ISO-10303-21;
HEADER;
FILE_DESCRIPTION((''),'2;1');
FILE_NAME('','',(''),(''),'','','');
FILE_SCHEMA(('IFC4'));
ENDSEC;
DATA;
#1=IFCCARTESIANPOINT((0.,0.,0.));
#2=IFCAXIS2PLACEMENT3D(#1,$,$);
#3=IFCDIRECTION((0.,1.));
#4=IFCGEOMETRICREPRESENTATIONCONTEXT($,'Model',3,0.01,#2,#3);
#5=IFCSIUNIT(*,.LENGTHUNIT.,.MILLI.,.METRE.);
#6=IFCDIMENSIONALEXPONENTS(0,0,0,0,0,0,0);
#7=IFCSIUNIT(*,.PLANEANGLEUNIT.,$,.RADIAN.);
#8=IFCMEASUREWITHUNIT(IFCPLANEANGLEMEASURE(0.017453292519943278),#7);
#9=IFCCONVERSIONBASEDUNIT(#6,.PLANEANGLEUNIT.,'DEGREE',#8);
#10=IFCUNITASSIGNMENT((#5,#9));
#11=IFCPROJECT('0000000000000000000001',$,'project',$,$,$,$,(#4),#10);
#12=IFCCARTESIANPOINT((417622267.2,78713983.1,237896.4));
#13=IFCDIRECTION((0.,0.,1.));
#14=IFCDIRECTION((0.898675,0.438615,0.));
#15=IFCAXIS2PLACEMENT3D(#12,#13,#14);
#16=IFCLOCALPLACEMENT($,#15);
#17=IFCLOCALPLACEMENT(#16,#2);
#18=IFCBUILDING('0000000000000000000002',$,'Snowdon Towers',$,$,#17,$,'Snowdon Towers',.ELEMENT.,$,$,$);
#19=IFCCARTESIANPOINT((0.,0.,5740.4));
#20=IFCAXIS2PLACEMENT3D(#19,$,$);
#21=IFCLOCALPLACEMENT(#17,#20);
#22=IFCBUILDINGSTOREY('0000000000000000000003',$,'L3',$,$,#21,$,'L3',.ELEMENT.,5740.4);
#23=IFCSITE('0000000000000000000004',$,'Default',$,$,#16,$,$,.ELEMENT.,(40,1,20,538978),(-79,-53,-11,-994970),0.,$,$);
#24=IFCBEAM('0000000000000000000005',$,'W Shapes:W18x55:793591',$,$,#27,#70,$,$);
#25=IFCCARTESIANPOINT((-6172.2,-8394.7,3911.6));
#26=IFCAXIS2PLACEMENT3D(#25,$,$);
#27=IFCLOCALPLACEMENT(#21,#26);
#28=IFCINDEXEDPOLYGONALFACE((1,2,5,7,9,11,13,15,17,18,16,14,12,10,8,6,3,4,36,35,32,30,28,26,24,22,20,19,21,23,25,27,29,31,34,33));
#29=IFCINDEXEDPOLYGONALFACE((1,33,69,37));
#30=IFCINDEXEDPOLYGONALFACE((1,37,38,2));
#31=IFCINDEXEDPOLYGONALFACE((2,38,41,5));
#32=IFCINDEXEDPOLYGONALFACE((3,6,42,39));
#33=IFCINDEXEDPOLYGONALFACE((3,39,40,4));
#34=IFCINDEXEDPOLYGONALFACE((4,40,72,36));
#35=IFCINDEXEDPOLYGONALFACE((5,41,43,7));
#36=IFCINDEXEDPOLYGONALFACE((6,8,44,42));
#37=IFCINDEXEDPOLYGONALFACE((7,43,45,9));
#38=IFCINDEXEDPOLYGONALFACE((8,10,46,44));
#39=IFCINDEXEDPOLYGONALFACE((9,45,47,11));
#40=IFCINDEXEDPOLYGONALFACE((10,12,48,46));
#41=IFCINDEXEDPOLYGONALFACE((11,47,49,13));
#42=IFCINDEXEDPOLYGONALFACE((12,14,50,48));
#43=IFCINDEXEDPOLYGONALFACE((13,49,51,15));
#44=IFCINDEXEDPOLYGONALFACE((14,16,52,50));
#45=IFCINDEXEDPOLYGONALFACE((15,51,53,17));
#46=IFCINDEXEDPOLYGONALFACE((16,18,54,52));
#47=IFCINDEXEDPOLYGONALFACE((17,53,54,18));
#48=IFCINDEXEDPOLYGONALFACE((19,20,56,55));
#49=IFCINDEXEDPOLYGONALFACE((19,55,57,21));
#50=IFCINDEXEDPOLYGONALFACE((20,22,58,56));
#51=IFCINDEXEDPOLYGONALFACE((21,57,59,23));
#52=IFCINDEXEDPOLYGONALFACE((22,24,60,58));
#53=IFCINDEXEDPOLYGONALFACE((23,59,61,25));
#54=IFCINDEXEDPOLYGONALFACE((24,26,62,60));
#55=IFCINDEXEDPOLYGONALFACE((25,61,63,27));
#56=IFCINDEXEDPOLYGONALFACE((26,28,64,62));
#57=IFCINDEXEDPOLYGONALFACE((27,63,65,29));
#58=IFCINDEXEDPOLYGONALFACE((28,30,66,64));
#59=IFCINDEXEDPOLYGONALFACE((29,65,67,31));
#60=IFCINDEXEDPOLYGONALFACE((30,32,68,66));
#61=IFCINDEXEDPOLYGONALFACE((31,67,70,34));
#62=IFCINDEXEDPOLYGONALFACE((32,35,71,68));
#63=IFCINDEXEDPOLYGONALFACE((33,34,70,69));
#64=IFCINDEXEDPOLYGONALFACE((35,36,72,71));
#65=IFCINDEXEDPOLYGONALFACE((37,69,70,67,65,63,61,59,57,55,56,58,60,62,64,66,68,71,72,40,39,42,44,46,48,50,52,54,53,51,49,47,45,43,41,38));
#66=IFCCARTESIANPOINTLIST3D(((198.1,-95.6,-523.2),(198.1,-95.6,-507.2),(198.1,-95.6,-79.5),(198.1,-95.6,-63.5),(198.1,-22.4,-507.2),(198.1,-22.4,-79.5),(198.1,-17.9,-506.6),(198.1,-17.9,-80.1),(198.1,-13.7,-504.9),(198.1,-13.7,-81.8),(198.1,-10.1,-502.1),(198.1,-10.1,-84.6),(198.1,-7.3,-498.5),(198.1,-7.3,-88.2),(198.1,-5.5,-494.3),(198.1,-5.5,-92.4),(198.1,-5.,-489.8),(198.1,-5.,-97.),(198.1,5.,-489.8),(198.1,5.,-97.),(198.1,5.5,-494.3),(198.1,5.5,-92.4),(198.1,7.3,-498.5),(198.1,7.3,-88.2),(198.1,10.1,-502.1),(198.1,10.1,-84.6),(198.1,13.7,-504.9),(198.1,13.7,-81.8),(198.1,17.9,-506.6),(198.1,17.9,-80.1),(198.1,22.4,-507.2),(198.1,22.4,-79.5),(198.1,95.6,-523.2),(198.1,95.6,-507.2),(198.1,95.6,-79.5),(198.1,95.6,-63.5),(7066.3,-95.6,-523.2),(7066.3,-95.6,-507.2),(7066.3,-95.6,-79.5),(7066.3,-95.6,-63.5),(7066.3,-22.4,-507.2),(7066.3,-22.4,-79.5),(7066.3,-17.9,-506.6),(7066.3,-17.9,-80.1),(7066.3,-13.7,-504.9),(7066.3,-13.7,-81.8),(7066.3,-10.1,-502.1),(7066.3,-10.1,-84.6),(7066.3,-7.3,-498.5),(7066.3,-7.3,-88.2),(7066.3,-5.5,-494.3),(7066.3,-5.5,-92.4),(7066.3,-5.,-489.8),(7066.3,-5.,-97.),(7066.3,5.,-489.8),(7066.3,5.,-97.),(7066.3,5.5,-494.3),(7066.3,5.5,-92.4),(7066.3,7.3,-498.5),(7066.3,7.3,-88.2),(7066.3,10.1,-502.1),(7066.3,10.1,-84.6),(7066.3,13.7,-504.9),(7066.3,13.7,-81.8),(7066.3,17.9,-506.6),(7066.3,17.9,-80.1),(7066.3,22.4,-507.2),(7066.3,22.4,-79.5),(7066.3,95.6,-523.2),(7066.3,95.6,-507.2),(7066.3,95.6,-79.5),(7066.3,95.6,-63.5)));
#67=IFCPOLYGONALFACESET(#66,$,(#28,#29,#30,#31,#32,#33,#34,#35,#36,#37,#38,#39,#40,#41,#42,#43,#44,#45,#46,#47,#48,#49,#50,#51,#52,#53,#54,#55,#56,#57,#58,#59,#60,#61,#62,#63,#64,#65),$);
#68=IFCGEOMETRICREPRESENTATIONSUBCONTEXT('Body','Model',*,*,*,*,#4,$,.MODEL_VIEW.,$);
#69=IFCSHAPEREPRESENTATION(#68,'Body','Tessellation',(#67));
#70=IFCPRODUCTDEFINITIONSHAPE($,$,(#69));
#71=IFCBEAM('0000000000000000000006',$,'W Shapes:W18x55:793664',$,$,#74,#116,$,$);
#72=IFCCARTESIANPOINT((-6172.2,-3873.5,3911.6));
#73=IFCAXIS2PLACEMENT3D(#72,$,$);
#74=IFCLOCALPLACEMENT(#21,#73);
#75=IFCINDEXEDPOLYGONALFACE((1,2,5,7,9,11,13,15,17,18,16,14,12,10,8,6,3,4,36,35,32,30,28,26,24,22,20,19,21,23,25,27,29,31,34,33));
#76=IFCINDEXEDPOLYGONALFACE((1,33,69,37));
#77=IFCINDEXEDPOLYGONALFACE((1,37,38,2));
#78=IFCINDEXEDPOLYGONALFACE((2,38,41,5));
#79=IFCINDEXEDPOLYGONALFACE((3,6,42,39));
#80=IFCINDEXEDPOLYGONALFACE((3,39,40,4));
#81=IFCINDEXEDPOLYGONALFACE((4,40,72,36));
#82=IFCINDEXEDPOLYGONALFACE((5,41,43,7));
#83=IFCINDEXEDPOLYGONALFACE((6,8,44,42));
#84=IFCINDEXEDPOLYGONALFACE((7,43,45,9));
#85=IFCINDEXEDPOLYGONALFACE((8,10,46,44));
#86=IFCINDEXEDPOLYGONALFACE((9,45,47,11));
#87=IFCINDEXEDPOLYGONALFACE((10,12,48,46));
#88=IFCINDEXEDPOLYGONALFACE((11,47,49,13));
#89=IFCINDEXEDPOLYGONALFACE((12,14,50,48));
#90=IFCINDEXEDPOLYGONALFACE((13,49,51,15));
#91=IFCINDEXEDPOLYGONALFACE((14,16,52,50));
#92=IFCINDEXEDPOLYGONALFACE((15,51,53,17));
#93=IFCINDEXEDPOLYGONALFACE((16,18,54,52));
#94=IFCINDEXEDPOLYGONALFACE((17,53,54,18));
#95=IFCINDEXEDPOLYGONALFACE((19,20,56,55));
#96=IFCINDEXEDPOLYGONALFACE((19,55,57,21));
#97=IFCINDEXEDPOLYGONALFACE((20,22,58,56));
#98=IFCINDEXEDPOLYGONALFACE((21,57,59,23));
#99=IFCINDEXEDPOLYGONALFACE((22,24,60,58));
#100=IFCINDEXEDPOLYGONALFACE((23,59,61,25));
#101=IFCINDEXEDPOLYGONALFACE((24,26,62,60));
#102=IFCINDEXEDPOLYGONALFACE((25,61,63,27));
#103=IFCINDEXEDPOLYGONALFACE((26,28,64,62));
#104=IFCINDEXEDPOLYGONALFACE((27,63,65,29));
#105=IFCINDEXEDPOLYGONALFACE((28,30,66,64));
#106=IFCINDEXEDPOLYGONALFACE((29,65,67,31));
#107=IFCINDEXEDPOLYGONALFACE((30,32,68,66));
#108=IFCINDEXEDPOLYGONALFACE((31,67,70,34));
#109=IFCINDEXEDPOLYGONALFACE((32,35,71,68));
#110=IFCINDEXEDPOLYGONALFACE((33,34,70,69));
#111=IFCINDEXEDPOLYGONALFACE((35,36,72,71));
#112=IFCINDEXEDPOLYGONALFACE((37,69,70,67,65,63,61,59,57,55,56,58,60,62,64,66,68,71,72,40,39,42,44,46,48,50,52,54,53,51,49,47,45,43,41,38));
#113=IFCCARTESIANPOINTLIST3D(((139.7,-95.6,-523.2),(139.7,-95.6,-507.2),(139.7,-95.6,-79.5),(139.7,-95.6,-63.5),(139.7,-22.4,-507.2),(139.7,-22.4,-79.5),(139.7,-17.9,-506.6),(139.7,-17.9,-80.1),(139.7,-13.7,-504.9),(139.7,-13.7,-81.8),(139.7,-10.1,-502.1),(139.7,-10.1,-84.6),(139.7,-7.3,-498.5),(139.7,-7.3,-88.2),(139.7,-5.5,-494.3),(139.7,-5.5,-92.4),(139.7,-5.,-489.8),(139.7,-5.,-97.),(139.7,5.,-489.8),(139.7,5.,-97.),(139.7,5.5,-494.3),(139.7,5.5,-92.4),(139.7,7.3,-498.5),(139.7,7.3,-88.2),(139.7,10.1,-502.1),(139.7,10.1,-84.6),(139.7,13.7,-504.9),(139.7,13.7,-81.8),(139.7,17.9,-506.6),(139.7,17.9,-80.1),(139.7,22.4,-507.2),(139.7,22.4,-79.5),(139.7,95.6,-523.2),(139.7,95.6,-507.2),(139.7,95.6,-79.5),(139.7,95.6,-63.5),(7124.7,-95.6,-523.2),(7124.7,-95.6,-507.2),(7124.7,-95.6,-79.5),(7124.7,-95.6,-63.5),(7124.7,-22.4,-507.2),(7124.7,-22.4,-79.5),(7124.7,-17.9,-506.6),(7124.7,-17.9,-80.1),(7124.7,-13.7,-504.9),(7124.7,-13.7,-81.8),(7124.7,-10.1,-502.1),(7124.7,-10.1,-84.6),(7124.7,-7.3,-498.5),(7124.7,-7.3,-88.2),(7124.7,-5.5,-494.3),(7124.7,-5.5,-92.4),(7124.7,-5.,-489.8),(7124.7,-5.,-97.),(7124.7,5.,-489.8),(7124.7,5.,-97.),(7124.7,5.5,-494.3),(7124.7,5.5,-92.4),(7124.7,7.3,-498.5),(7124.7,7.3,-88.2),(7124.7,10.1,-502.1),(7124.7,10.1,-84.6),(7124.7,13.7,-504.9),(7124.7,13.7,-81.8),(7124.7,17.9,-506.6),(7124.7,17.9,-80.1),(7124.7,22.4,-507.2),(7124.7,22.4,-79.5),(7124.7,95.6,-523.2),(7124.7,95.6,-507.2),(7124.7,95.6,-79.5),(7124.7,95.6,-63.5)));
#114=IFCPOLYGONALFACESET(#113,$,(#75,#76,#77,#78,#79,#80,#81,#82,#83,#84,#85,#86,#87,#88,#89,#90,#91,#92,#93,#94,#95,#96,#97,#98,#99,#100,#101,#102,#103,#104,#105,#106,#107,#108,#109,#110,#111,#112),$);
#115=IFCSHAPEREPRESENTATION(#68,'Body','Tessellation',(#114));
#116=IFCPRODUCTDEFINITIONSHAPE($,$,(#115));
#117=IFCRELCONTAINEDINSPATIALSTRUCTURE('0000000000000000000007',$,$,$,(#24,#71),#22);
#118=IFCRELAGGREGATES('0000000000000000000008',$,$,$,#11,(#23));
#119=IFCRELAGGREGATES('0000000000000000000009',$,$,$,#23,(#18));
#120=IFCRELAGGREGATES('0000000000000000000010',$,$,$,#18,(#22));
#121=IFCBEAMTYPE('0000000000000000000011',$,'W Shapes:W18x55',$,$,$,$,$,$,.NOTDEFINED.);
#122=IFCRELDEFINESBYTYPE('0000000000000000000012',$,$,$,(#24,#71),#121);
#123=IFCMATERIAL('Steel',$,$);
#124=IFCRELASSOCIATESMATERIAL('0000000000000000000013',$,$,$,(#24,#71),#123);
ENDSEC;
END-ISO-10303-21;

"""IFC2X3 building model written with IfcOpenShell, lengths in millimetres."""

from ifc_helpers import new_model, entity, si_unit, converted_unit, direction, frame, frame_2d, origin, place, context, subcontext, project, spatial, i_section, extrude, material, type_object, element, save


model = new_model("IFC2X3")

# Units and contexts
model_context = context("Model", 3, precision=0.01, world=origin(), true_north=direction((0.0, 1.0)))
body_context = subcontext(model_context, "Body", "Model", "MODEL_VIEW")
ifc_project = project(units=[si_unit("LENGTHUNIT", "METRE", prefix="MILLI"), converted_unit("PLANEANGLEUNIT", "DEGREE", entity("IfcPlaneAngleMeasure", 0.017453292519943278), si_unit("PLANEANGLEUNIT", "RADIAN"), dimensions=[0, 0, 0, 0, 0, 0, 0])], contexts=[model_context])

# Site, building, storey
site_placement = place(None, frame((417622267.2, 78713983.1, 237896.4), z_axis=(0.0, 0.0, 1.0), x_axis=(0.898675, 0.438615, 0.0)))
site = spatial("IfcSite", under=ifc_project, at=site_placement, Name="Default", CompositionType="ELEMENT", RefLatitude=(40, 1, 20, 538978), RefLongitude=(-79, -53, -11, -994970), RefElevation=0.0)
building_placement = place(site_placement, origin())
building = spatial("IfcBuilding", under=site, at=building_placement, Name="Snowdon Towers", LongName="Snowdon Towers", CompositionType="ELEMENT")
storey_placement = place(building_placement, frame((0.0, 0.0, 5740.4)))
storey = spatial("IfcBuildingStorey", under=building, at=storey_placement, Name="L3", LongName="L3", CompositionType="ELEMENT", Elevation=5740.4)

# Shared definitions
ifc_material_1 = material(Name="Steel")

# Beams
beam_type = type_object("IfcBeamType", Name="W Shapes:W18x55", PredefinedType="NOTDEFINED")
beam_1_placement = place(storey_placement, frame((-6172.2, -8394.7, 3911.6)))
element("IfcBeam", 1, at=beam_1_placement, inside=storey, type_object=beam_type, material=ifc_material_1, Name="W Shapes:W18x55:793591", context=body_context, shape_type="SweptSolid", body=[
    extrude(i_section(OverallWidth=191.3, OverallDepth=459.7, WebThickness=9.9, FlangeThickness=16.0, FilletRadius=17.5, at=frame_2d((0.0, 0.0), x_axis=(0.0, 1.0))), frame((198.1, 0.0, -293.4), z_axis=(1.0, 0.0, 0.0), x_axis=(0.0, 0.0, -1.0)), (0.0, 0.0, 1.0), 6868.2),
])
beam_2_placement = place(storey_placement, frame((-6172.2, -3873.5, 3911.6)))
element("IfcBeam", 2, at=beam_2_placement, inside=storey, type_object=beam_type, material=ifc_material_1, Name="W Shapes:W18x55:793664", context=body_context, shape_type="SweptSolid", body=[
    extrude(i_section(OverallWidth=191.3, OverallDepth=459.7, WebThickness=9.9, FlangeThickness=16.0, FilletRadius=17.5, at=frame_2d((0.0, 0.0), x_axis=(0.0, 1.0))), frame((139.7, 0.0, -293.4), z_axis=(1.0, 0.0, 0.0), x_axis=(0.0, 0.0, -1.0)), (0.0, 0.0, 1.0), 6985.0),
])

save(model, "model.ifc")
